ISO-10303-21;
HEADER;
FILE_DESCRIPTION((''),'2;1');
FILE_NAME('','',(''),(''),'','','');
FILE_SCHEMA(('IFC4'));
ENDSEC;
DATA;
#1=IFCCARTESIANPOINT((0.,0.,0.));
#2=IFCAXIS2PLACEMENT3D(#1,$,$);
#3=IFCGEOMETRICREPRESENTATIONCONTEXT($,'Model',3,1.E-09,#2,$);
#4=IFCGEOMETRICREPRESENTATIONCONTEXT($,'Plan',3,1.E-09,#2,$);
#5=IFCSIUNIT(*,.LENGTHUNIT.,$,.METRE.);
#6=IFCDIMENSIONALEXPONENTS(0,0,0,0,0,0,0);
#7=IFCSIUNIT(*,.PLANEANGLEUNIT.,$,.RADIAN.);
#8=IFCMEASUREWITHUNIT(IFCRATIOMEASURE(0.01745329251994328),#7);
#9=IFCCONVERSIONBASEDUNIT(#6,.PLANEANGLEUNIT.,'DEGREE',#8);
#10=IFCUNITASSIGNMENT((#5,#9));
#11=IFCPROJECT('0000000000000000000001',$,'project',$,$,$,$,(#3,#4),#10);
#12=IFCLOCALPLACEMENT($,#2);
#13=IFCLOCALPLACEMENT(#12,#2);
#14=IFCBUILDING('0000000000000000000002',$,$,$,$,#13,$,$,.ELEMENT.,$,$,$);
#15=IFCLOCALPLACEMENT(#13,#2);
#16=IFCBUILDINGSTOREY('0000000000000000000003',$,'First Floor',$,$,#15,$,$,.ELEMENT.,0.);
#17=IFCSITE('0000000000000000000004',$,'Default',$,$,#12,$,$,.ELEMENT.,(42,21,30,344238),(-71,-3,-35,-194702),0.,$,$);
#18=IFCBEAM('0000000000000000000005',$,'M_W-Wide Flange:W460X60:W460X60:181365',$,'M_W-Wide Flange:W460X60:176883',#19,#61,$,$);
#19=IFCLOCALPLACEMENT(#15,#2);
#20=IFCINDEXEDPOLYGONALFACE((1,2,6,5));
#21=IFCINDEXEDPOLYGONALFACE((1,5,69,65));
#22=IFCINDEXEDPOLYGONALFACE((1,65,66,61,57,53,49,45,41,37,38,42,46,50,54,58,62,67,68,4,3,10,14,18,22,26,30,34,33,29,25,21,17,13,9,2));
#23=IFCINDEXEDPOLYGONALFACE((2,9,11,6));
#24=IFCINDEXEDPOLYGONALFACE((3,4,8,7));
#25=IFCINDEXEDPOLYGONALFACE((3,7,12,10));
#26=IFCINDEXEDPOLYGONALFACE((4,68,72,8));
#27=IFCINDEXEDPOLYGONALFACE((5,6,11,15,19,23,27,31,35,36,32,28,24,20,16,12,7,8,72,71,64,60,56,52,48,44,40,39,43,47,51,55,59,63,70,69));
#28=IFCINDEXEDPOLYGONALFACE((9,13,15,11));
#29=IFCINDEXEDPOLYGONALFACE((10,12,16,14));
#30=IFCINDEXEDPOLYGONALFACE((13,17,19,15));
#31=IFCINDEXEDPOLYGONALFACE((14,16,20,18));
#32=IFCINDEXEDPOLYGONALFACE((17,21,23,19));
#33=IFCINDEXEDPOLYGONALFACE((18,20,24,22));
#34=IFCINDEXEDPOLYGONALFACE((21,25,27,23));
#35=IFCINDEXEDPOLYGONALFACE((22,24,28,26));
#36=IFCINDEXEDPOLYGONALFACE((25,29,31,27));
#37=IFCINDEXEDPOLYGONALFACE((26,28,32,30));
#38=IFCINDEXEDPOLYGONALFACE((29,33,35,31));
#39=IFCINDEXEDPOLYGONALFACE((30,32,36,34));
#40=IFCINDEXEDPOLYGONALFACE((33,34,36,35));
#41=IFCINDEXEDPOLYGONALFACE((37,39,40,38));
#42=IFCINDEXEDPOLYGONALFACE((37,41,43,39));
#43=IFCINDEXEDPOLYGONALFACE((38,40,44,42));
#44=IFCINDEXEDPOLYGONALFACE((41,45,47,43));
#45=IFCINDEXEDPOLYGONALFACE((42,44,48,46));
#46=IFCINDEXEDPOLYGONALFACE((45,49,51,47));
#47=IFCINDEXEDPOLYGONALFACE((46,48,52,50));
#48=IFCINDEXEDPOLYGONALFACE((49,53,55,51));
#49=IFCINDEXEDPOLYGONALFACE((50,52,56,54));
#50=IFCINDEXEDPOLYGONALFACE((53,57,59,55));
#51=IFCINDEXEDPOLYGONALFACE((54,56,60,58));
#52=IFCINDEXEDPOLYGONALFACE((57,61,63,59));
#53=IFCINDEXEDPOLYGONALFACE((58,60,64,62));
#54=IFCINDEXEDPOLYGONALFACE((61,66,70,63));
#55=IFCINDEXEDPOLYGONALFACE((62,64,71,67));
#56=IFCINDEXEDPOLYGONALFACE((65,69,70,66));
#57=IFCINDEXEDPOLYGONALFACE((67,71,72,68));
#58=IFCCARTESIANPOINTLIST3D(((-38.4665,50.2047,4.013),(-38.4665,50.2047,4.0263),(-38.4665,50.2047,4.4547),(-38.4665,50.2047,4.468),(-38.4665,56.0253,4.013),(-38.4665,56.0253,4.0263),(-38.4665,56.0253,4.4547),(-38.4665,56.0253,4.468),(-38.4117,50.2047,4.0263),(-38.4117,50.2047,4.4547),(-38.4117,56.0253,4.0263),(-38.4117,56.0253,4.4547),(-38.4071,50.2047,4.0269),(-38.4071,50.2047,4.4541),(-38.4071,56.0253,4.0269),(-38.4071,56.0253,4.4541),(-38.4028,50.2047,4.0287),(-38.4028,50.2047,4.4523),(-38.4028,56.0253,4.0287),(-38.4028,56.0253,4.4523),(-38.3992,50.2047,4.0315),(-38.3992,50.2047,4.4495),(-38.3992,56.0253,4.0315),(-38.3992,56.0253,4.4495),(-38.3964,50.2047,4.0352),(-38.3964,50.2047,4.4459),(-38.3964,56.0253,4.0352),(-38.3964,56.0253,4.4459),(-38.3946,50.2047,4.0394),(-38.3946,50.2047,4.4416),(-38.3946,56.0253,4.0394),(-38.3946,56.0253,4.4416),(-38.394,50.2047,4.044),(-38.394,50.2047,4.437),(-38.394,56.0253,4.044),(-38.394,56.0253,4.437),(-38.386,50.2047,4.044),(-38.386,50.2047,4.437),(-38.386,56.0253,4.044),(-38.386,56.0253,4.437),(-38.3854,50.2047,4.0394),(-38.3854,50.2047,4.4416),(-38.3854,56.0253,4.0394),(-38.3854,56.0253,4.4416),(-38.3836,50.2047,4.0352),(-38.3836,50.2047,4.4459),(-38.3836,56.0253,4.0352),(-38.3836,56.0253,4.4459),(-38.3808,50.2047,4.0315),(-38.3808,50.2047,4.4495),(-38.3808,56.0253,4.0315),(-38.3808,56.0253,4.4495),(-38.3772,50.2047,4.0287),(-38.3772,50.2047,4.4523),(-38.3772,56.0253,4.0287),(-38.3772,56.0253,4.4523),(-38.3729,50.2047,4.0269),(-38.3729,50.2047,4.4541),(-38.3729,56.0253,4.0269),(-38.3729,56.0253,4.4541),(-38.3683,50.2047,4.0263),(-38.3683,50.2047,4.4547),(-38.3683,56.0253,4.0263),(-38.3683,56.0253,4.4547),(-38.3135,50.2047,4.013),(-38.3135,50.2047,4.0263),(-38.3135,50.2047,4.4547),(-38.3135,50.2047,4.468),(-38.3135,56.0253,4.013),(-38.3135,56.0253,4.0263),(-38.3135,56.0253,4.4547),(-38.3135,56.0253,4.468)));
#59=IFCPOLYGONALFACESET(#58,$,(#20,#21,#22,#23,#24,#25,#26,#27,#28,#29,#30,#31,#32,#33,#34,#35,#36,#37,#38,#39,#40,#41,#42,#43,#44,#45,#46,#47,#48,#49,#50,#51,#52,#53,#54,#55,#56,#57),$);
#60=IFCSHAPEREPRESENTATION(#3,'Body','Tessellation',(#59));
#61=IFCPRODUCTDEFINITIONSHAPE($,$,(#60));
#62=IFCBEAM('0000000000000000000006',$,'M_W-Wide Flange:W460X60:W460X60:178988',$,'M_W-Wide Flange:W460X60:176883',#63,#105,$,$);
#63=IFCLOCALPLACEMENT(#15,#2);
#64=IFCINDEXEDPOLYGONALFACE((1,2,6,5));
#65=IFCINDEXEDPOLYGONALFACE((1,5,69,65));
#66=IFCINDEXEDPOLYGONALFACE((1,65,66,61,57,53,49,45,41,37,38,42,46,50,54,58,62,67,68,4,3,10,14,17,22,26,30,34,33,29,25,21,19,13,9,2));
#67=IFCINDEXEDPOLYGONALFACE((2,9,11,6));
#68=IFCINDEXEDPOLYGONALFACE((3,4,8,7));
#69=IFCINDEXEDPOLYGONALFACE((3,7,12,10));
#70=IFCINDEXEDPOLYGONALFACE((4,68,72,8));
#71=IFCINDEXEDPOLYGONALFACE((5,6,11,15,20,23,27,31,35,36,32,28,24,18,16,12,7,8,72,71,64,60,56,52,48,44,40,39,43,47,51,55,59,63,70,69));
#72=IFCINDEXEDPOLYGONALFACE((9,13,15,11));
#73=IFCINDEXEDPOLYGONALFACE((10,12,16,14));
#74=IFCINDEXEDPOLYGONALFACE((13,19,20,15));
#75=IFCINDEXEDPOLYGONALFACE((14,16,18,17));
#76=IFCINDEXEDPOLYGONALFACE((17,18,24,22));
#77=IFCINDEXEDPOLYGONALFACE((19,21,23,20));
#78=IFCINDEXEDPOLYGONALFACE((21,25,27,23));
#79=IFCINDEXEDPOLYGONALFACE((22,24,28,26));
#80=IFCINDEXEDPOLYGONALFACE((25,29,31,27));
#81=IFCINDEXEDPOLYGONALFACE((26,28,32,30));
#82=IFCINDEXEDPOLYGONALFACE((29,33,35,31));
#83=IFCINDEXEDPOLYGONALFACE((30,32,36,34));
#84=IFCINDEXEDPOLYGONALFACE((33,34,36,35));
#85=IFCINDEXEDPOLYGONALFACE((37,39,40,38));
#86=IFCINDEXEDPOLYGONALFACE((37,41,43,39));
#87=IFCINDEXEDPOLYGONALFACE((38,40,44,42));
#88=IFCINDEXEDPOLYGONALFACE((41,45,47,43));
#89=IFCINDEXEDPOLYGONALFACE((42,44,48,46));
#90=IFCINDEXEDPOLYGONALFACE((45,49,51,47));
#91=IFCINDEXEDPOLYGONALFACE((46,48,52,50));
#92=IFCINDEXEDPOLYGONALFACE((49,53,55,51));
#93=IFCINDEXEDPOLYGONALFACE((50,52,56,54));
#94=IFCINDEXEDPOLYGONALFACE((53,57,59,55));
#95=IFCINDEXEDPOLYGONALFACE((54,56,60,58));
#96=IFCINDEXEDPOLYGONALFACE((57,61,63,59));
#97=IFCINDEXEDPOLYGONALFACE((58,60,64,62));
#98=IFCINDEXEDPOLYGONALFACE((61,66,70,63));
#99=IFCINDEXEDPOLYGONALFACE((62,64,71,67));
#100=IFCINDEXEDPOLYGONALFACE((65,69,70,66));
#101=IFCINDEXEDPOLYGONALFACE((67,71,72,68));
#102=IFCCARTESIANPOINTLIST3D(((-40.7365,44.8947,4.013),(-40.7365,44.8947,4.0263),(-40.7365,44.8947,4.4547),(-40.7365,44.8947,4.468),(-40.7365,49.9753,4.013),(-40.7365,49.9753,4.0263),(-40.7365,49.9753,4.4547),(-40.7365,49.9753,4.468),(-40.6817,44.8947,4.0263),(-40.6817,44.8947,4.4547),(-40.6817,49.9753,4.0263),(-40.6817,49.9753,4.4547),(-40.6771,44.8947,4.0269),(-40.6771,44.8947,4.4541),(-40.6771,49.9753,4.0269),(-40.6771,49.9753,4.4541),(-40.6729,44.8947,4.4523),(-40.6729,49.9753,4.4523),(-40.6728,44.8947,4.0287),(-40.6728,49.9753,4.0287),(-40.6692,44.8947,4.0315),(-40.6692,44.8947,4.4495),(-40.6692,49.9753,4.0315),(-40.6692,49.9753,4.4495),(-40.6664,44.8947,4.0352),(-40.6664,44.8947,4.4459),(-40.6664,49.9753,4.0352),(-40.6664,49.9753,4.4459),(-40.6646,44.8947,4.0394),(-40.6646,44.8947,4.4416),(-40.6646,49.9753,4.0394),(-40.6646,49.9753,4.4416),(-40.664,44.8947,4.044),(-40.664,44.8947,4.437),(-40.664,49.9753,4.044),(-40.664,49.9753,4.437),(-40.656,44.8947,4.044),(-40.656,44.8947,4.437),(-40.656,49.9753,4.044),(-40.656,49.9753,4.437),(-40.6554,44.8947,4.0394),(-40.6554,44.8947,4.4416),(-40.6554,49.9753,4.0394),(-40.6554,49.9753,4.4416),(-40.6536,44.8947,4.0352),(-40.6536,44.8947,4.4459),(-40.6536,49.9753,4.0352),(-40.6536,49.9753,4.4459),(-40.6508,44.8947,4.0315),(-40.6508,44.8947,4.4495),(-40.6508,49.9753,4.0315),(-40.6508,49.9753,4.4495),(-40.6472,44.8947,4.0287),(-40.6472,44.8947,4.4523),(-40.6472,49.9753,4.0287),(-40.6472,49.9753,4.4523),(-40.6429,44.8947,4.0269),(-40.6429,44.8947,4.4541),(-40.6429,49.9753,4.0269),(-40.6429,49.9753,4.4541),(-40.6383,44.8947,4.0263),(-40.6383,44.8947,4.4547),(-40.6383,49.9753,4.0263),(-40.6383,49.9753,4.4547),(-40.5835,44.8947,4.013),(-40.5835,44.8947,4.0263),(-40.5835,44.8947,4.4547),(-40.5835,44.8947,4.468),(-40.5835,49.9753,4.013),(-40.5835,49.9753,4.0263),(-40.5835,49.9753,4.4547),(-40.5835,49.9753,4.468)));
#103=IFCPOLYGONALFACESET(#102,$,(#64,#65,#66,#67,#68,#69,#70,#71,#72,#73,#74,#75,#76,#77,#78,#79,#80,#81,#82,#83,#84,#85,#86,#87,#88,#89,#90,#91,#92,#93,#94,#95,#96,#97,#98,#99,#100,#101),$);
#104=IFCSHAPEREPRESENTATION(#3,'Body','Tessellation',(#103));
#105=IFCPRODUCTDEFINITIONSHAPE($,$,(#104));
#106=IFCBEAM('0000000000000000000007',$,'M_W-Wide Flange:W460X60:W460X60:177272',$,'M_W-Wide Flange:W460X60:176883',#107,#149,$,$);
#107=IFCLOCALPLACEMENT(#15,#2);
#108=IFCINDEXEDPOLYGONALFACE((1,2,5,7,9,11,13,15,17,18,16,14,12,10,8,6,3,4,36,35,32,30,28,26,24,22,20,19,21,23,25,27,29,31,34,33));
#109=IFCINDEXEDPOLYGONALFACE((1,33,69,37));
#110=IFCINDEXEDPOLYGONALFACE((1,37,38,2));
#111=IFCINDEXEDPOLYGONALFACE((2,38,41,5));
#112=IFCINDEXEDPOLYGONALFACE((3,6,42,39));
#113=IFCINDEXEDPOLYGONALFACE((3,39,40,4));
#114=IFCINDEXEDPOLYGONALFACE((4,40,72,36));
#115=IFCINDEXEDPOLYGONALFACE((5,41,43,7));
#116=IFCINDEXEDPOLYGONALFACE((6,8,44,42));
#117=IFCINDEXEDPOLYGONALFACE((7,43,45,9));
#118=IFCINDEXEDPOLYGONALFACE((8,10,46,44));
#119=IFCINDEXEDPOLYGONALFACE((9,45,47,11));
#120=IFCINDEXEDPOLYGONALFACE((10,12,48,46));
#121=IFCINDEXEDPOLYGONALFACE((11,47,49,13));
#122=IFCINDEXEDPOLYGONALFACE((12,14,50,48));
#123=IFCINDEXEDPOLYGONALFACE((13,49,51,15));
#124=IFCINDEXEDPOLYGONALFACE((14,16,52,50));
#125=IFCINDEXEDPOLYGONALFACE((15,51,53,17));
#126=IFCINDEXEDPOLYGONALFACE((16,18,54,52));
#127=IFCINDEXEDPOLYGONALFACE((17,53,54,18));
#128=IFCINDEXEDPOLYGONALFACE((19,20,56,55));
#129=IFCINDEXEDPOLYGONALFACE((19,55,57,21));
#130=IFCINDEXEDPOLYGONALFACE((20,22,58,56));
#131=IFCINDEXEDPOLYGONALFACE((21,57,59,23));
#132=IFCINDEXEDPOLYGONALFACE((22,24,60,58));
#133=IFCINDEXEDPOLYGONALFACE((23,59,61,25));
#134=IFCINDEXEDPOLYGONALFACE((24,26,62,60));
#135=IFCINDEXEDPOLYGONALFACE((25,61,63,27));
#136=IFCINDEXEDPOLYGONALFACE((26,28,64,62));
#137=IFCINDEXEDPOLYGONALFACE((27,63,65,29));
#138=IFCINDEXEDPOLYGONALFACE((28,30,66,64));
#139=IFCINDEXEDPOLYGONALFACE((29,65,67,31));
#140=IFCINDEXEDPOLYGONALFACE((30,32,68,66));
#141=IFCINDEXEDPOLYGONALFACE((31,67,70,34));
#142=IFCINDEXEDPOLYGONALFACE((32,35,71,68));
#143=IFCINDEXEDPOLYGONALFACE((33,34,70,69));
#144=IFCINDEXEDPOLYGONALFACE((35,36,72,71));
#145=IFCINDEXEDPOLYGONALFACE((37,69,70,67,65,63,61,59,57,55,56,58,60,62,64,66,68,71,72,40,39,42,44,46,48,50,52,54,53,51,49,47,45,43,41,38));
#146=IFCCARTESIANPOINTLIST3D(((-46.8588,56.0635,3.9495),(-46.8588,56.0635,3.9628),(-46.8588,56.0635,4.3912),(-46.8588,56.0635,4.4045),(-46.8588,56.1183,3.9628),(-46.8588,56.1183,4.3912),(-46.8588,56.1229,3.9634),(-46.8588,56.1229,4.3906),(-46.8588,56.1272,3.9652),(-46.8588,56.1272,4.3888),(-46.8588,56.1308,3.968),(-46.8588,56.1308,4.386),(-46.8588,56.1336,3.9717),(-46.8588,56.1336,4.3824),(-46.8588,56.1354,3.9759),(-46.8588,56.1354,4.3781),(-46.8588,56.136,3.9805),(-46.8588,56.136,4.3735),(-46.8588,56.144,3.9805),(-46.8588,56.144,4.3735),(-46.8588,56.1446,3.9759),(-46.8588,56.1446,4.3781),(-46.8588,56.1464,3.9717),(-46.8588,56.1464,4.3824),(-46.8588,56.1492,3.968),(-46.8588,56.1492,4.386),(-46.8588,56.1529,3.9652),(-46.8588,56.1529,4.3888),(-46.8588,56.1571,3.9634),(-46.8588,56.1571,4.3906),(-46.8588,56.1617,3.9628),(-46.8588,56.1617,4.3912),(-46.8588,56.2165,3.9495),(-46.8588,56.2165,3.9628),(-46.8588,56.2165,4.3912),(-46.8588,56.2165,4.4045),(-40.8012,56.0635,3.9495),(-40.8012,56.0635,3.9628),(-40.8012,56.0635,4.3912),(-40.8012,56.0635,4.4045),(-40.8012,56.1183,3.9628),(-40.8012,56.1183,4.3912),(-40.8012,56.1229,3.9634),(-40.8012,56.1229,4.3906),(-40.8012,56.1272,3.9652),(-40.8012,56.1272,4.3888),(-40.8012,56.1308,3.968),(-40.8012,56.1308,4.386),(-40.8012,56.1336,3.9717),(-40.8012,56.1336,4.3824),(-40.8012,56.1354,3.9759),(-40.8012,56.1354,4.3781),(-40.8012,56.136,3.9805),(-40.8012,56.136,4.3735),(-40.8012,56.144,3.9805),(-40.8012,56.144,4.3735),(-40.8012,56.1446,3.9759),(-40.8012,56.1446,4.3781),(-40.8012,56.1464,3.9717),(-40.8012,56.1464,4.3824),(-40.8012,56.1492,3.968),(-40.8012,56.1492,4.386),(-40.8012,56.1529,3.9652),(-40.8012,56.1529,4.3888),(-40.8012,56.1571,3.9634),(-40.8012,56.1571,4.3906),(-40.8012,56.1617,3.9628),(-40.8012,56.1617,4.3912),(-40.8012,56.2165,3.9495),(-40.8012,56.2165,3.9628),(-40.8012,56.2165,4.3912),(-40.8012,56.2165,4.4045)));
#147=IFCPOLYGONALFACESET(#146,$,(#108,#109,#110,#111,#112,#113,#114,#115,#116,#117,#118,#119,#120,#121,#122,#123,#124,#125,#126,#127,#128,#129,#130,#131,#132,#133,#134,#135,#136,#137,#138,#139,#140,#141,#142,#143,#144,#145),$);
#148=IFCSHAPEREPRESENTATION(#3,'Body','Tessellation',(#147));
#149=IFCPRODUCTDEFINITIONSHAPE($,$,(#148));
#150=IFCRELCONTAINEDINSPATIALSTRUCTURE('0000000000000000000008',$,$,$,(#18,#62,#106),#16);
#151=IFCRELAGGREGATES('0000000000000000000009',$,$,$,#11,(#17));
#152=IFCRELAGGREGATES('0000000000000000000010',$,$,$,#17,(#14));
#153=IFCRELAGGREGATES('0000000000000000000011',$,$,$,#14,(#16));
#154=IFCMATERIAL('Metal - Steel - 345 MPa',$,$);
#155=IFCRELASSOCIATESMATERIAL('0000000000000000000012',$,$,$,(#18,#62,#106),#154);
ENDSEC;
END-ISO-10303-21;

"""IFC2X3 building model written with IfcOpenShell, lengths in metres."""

from ifc_helpers import new_model, entity, si_unit, converted_unit, frame, frame_2d, origin, place, context, project, spatial, polyline, circle_curve, parameter, trimmed, segment, composite_curve, outline, extrude, material, element, save


model = new_model("IFC2X3")

# Units and contexts
model_context = context("Model", 3, precision=1e-09, world=origin())
plan_context = context("Plan", 3, precision=1e-09, world=origin())
ifc_project = project(units=[si_unit("LENGTHUNIT", "METRE"), converted_unit("PLANEANGLEUNIT", "DEGREE", entity("IfcRatioMeasure", 0.01745329251994328), si_unit("PLANEANGLEUNIT", "RADIAN"), dimensions=[0, 0, 0, 0, 0, 0, 0])], contexts=[model_context, plan_context])

# Site, building, storey
site_placement = place(None, origin())
site = spatial("IfcSite", under=ifc_project, at=site_placement, Name="Default", CompositionType="ELEMENT", RefLatitude=(42, 21, 30, 344238), RefLongitude=(-71, -3, -35, -194702), RefElevation=0.0)
building_placement = place(site_placement, origin())
building = spatial("IfcBuilding", under=site, at=building_placement, CompositionType="ELEMENT")
storey_placement = place(building_placement, origin())
storey = spatial("IfcBuildingStorey", under=building, at=storey_placement, Name="First Floor", CompositionType="ELEMENT", Elevation=0.0)

# Beams
ifc_material = material(Name="Metal - Steel - 345 MPa")
beam_1_placement = place(storey_placement, frame((-38.39, 50.0877, 4.468)))
element("IfcBeam", 1, at=beam_1_placement, inside=storey, material=ifc_material, Name="M_W-Wide Flange:W460X60:W460X60:181365", ObjectType="M_W-Wide Flange:W460X60:176883", context=model_context, shape_type="SweptSolid", body=[
    extrude(outline(composite_curve([segment(polyline([(-0.0765, -0.2142), (-0.0765, -0.2275)]), True, "CONTINUOUS"), segment(polyline([(-0.0765, -0.2275), (0.0765, -0.2275)]), True, "CONTINUOUS"), segment(polyline([(0.0765, -0.2275), (0.0765, -0.2142)]), True, "CONTINUOUS"), segment(polyline([(0.0765, -0.2142), (0.0217, -0.2142)]), True, "CONTINUOUS"), segment(trimmed(circle_curve(frame_2d((0.0217, -0.1965), x_axis=(1.0, 0.0)), 0.0177), [parameter(180.0)], [parameter(270.0)], True, "PARAMETER"), False, "CONTINUOUS"), segment(polyline([(0.004, -0.1965), (0.004, 0.1965)]), True, "CONTINUOUS"), segment(trimmed(circle_curve(frame_2d((0.0217, 0.1965), x_axis=(1.0, 0.0)), 0.0177), [parameter(90.0)], [parameter(180.0)], True, "PARAMETER"), False, "CONTINUOUS"), segment(polyline([(0.0217, 0.2142), (0.0765, 0.2142)]), True, "CONTINUOUS"), segment(polyline([(0.0765, 0.2142), (0.0765, 0.2275)]), True, "CONTINUOUS"), segment(polyline([(0.0765, 0.2275), (-0.0765, 0.2275)]), True, "CONTINUOUS"), segment(polyline([(-0.0765, 0.2275), (-0.0765, 0.2142)]), True, "CONTINUOUS"), segment(polyline([(-0.0765, 0.2142), (-0.0217, 0.2142)]), True, "CONTINUOUS"), segment(trimmed(circle_curve(frame_2d((-0.0217, 0.1965), x_axis=(1.0, 0.0)), 0.0177), [parameter(360.0)], [parameter(90.0)], True, "PARAMETER"), False, "CONTINUOUS"), segment(polyline([(-0.004, 0.1965), (-0.004, -0.1965)]), True, "CONTINUOUS"), segment(trimmed(circle_curve(frame_2d((-0.0217, -0.1965), x_axis=(1.0, 0.0)), 0.0177), [parameter(270.0)], [parameter(0.0)], True, "PARAMETER"), False, "CONTINUOUS"), segment(polyline([(-0.0217, -0.2142), (-0.0765, -0.2142)]), True, "CONTINUOUS")], self_intersect=False)), frame((0.0, 0.117, -0.2275), z_axis=(0.0, -1.0, 0.0), x_axis=(1.0, 0.0, 0.0)), (0.0, 0.0, -1.0), 5.8206),
])
beam_2_placement = place(storey_placement, frame((-40.66, 50.0926, 4.468), z_axis=(0.0, 0.0, 1.0), x_axis=(-1.0, 0.0, 0.0)))
element("IfcBeam", 2, at=beam_2_placement, inside=storey, material=ifc_material, Name="M_W-Wide Flange:W460X60:W460X60:178988", ObjectType="M_W-Wide Flange:W460X60:176883", context=model_context, shape_type="SweptSolid", body=[
    extrude(outline(composite_curve([segment(polyline([(0.2142, -0.0765), (0.2275, -0.0765)]), True, "CONTINUOUS"), segment(polyline([(0.2275, -0.0765), (0.2275, 0.0765)]), True, "CONTINUOUS"), segment(polyline([(0.2275, 0.0765), (0.2142, 0.0765)]), True, "CONTINUOUS"), segment(polyline([(0.2142, 0.0765), (0.2142, 0.0217)]), True, "CONTINUOUS"), segment(trimmed(circle_curve(frame_2d((0.1965, 0.0217), x_axis=(1.0, 0.0)), 0.0177), [parameter(270.0)], [parameter(360.0)], True, "PARAMETER"), False, "CONTINUOUS"), segment(polyline([(0.1965, 0.004), (-0.1965, 0.004)]), True, "CONTINUOUS"), segment(trimmed(circle_curve(frame_2d((-0.1965, 0.0217), x_axis=(0.0, -1.0)), 0.0177), [parameter(270.0)], [parameter(360.0)], True, "PARAMETER"), False, "CONTINUOUS"), segment(polyline([(-0.2142, 0.0217), (-0.2142, 0.0765)]), True, "CONTINUOUS"), segment(polyline([(-0.2142, 0.0765), (-0.2275, 0.0765)]), True, "CONTINUOUS"), segment(polyline([(-0.2275, 0.0765), (-0.2275, -0.0765)]), True, "CONTINUOUS"), segment(polyline([(-0.2275, -0.0765), (-0.2142, -0.0765)]), True, "CONTINUOUS"), segment(polyline([(-0.2142, -0.0765), (-0.2142, -0.0217)]), True, "CONTINUOUS"), segment(trimmed(circle_curve(frame_2d((-0.1965, -0.0217), x_axis=(-1.0, 0.0)), 0.0177), [parameter(270.0)], [parameter(360.0)], True, "PARAMETER"), False, "CONTINUOUS"), segment(polyline([(-0.1965, -0.004), (0.1965, -0.004)]), True, "CONTINUOUS"), segment(trimmed(circle_curve(frame_2d((0.1965, -0.0217), x_axis=(0.0, 1.0)), 0.0177), [parameter(270.0)], [parameter(0.0)], True, "PARAMETER"), False, "CONTINUOUS"), segment(polyline([(0.2142, -0.0217), (0.2142, -0.0765)]), True, "CONTINUOUS")], self_intersect=False)), frame((0.0, 5.1979, -0.2275), z_axis=(0.0, -1.0, 0.0), x_axis=(0.0, 0.0, -1.0)), (0.0, 0.0, 1.0), 5.0806),
])
beam_3_placement = place(storey_placement, frame((-46.9978, 56.14, 4.4045), z_axis=(0.0, 0.0, 1.0), x_axis=(0.0, -1.0, 0.0)))
element("IfcBeam", 3, at=beam_3_placement, inside=storey, material=ifc_material, Name="M_W-Wide Flange:W460X60:W460X60:177272", ObjectType="M_W-Wide Flange:W460X60:176883", context=model_context, shape_type="SweptSolid", body=[
    extrude(outline(composite_curve([segment(polyline([(-0.0765, -0.2142), (-0.0765, -0.2275)]), True, "CONTINUOUS"), segment(polyline([(-0.0765, -0.2275), (0.0765, -0.2275)]), True, "CONTINUOUS"), segment(polyline([(0.0765, -0.2275), (0.0765, -0.2142)]), True, "CONTINUOUS"), segment(polyline([(0.0765, -0.2142), (0.0217, -0.2142)]), True, "CONTINUOUS"), segment(trimmed(circle_curve(frame_2d((0.0217, -0.1965), x_axis=(1.0, 0.0)), 0.0177), [parameter(180.0)], [parameter(270.0)], True, "PARAMETER"), False, "CONTINUOUS"), segment(polyline([(0.004, -0.1965), (0.004, 0.1965)]), True, "CONTINUOUS"), segment(trimmed(circle_curve(frame_2d((0.0217, 0.1965), x_axis=(1.0, 0.0)), 0.0177), [parameter(90.0)], [parameter(180.0)], True, "PARAMETER"), False, "CONTINUOUS"), segment(polyline([(0.0217, 0.2142), (0.0765, 0.2142)]), True, "CONTINUOUS"), segment(polyline([(0.0765, 0.2142), (0.0765, 0.2275)]), True, "CONTINUOUS"), segment(polyline([(0.0765, 0.2275), (-0.0765, 0.2275)]), True, "CONTINUOUS"), segment(polyline([(-0.0765, 0.2275), (-0.0765, 0.2142)]), True, "CONTINUOUS"), segment(polyline([(-0.0765, 0.2142), (-0.0217, 0.2142)]), True, "CONTINUOUS"), segment(trimmed(circle_curve(frame_2d((-0.0217, 0.1965), x_axis=(1.0, 0.0)), 0.0177), [parameter(360.0)], [parameter(90.0)], True, "PARAMETER"), False, "CONTINUOUS"), segment(polyline([(-0.004, 0.1965), (-0.004, -0.1965)]), True, "CONTINUOUS"), segment(trimmed(circle_curve(frame_2d((-0.0217, -0.1965), x_axis=(1.0, 0.0)), 0.0177), [parameter(270.0)], [parameter(0.0)], True, "PARAMETER"), False, "CONTINUOUS"), segment(polyline([(-0.0217, -0.2142), (-0.0765, -0.2142)]), True, "CONTINUOUS")], self_intersect=False)), frame((0.0, 0.139, -0.2275), z_axis=(0.0, -1.0, 0.0), x_axis=(1.0, 0.0, 0.0)), (0.0, 0.0, -1.0), 6.0576),
])

save(model, "model.ifc")
